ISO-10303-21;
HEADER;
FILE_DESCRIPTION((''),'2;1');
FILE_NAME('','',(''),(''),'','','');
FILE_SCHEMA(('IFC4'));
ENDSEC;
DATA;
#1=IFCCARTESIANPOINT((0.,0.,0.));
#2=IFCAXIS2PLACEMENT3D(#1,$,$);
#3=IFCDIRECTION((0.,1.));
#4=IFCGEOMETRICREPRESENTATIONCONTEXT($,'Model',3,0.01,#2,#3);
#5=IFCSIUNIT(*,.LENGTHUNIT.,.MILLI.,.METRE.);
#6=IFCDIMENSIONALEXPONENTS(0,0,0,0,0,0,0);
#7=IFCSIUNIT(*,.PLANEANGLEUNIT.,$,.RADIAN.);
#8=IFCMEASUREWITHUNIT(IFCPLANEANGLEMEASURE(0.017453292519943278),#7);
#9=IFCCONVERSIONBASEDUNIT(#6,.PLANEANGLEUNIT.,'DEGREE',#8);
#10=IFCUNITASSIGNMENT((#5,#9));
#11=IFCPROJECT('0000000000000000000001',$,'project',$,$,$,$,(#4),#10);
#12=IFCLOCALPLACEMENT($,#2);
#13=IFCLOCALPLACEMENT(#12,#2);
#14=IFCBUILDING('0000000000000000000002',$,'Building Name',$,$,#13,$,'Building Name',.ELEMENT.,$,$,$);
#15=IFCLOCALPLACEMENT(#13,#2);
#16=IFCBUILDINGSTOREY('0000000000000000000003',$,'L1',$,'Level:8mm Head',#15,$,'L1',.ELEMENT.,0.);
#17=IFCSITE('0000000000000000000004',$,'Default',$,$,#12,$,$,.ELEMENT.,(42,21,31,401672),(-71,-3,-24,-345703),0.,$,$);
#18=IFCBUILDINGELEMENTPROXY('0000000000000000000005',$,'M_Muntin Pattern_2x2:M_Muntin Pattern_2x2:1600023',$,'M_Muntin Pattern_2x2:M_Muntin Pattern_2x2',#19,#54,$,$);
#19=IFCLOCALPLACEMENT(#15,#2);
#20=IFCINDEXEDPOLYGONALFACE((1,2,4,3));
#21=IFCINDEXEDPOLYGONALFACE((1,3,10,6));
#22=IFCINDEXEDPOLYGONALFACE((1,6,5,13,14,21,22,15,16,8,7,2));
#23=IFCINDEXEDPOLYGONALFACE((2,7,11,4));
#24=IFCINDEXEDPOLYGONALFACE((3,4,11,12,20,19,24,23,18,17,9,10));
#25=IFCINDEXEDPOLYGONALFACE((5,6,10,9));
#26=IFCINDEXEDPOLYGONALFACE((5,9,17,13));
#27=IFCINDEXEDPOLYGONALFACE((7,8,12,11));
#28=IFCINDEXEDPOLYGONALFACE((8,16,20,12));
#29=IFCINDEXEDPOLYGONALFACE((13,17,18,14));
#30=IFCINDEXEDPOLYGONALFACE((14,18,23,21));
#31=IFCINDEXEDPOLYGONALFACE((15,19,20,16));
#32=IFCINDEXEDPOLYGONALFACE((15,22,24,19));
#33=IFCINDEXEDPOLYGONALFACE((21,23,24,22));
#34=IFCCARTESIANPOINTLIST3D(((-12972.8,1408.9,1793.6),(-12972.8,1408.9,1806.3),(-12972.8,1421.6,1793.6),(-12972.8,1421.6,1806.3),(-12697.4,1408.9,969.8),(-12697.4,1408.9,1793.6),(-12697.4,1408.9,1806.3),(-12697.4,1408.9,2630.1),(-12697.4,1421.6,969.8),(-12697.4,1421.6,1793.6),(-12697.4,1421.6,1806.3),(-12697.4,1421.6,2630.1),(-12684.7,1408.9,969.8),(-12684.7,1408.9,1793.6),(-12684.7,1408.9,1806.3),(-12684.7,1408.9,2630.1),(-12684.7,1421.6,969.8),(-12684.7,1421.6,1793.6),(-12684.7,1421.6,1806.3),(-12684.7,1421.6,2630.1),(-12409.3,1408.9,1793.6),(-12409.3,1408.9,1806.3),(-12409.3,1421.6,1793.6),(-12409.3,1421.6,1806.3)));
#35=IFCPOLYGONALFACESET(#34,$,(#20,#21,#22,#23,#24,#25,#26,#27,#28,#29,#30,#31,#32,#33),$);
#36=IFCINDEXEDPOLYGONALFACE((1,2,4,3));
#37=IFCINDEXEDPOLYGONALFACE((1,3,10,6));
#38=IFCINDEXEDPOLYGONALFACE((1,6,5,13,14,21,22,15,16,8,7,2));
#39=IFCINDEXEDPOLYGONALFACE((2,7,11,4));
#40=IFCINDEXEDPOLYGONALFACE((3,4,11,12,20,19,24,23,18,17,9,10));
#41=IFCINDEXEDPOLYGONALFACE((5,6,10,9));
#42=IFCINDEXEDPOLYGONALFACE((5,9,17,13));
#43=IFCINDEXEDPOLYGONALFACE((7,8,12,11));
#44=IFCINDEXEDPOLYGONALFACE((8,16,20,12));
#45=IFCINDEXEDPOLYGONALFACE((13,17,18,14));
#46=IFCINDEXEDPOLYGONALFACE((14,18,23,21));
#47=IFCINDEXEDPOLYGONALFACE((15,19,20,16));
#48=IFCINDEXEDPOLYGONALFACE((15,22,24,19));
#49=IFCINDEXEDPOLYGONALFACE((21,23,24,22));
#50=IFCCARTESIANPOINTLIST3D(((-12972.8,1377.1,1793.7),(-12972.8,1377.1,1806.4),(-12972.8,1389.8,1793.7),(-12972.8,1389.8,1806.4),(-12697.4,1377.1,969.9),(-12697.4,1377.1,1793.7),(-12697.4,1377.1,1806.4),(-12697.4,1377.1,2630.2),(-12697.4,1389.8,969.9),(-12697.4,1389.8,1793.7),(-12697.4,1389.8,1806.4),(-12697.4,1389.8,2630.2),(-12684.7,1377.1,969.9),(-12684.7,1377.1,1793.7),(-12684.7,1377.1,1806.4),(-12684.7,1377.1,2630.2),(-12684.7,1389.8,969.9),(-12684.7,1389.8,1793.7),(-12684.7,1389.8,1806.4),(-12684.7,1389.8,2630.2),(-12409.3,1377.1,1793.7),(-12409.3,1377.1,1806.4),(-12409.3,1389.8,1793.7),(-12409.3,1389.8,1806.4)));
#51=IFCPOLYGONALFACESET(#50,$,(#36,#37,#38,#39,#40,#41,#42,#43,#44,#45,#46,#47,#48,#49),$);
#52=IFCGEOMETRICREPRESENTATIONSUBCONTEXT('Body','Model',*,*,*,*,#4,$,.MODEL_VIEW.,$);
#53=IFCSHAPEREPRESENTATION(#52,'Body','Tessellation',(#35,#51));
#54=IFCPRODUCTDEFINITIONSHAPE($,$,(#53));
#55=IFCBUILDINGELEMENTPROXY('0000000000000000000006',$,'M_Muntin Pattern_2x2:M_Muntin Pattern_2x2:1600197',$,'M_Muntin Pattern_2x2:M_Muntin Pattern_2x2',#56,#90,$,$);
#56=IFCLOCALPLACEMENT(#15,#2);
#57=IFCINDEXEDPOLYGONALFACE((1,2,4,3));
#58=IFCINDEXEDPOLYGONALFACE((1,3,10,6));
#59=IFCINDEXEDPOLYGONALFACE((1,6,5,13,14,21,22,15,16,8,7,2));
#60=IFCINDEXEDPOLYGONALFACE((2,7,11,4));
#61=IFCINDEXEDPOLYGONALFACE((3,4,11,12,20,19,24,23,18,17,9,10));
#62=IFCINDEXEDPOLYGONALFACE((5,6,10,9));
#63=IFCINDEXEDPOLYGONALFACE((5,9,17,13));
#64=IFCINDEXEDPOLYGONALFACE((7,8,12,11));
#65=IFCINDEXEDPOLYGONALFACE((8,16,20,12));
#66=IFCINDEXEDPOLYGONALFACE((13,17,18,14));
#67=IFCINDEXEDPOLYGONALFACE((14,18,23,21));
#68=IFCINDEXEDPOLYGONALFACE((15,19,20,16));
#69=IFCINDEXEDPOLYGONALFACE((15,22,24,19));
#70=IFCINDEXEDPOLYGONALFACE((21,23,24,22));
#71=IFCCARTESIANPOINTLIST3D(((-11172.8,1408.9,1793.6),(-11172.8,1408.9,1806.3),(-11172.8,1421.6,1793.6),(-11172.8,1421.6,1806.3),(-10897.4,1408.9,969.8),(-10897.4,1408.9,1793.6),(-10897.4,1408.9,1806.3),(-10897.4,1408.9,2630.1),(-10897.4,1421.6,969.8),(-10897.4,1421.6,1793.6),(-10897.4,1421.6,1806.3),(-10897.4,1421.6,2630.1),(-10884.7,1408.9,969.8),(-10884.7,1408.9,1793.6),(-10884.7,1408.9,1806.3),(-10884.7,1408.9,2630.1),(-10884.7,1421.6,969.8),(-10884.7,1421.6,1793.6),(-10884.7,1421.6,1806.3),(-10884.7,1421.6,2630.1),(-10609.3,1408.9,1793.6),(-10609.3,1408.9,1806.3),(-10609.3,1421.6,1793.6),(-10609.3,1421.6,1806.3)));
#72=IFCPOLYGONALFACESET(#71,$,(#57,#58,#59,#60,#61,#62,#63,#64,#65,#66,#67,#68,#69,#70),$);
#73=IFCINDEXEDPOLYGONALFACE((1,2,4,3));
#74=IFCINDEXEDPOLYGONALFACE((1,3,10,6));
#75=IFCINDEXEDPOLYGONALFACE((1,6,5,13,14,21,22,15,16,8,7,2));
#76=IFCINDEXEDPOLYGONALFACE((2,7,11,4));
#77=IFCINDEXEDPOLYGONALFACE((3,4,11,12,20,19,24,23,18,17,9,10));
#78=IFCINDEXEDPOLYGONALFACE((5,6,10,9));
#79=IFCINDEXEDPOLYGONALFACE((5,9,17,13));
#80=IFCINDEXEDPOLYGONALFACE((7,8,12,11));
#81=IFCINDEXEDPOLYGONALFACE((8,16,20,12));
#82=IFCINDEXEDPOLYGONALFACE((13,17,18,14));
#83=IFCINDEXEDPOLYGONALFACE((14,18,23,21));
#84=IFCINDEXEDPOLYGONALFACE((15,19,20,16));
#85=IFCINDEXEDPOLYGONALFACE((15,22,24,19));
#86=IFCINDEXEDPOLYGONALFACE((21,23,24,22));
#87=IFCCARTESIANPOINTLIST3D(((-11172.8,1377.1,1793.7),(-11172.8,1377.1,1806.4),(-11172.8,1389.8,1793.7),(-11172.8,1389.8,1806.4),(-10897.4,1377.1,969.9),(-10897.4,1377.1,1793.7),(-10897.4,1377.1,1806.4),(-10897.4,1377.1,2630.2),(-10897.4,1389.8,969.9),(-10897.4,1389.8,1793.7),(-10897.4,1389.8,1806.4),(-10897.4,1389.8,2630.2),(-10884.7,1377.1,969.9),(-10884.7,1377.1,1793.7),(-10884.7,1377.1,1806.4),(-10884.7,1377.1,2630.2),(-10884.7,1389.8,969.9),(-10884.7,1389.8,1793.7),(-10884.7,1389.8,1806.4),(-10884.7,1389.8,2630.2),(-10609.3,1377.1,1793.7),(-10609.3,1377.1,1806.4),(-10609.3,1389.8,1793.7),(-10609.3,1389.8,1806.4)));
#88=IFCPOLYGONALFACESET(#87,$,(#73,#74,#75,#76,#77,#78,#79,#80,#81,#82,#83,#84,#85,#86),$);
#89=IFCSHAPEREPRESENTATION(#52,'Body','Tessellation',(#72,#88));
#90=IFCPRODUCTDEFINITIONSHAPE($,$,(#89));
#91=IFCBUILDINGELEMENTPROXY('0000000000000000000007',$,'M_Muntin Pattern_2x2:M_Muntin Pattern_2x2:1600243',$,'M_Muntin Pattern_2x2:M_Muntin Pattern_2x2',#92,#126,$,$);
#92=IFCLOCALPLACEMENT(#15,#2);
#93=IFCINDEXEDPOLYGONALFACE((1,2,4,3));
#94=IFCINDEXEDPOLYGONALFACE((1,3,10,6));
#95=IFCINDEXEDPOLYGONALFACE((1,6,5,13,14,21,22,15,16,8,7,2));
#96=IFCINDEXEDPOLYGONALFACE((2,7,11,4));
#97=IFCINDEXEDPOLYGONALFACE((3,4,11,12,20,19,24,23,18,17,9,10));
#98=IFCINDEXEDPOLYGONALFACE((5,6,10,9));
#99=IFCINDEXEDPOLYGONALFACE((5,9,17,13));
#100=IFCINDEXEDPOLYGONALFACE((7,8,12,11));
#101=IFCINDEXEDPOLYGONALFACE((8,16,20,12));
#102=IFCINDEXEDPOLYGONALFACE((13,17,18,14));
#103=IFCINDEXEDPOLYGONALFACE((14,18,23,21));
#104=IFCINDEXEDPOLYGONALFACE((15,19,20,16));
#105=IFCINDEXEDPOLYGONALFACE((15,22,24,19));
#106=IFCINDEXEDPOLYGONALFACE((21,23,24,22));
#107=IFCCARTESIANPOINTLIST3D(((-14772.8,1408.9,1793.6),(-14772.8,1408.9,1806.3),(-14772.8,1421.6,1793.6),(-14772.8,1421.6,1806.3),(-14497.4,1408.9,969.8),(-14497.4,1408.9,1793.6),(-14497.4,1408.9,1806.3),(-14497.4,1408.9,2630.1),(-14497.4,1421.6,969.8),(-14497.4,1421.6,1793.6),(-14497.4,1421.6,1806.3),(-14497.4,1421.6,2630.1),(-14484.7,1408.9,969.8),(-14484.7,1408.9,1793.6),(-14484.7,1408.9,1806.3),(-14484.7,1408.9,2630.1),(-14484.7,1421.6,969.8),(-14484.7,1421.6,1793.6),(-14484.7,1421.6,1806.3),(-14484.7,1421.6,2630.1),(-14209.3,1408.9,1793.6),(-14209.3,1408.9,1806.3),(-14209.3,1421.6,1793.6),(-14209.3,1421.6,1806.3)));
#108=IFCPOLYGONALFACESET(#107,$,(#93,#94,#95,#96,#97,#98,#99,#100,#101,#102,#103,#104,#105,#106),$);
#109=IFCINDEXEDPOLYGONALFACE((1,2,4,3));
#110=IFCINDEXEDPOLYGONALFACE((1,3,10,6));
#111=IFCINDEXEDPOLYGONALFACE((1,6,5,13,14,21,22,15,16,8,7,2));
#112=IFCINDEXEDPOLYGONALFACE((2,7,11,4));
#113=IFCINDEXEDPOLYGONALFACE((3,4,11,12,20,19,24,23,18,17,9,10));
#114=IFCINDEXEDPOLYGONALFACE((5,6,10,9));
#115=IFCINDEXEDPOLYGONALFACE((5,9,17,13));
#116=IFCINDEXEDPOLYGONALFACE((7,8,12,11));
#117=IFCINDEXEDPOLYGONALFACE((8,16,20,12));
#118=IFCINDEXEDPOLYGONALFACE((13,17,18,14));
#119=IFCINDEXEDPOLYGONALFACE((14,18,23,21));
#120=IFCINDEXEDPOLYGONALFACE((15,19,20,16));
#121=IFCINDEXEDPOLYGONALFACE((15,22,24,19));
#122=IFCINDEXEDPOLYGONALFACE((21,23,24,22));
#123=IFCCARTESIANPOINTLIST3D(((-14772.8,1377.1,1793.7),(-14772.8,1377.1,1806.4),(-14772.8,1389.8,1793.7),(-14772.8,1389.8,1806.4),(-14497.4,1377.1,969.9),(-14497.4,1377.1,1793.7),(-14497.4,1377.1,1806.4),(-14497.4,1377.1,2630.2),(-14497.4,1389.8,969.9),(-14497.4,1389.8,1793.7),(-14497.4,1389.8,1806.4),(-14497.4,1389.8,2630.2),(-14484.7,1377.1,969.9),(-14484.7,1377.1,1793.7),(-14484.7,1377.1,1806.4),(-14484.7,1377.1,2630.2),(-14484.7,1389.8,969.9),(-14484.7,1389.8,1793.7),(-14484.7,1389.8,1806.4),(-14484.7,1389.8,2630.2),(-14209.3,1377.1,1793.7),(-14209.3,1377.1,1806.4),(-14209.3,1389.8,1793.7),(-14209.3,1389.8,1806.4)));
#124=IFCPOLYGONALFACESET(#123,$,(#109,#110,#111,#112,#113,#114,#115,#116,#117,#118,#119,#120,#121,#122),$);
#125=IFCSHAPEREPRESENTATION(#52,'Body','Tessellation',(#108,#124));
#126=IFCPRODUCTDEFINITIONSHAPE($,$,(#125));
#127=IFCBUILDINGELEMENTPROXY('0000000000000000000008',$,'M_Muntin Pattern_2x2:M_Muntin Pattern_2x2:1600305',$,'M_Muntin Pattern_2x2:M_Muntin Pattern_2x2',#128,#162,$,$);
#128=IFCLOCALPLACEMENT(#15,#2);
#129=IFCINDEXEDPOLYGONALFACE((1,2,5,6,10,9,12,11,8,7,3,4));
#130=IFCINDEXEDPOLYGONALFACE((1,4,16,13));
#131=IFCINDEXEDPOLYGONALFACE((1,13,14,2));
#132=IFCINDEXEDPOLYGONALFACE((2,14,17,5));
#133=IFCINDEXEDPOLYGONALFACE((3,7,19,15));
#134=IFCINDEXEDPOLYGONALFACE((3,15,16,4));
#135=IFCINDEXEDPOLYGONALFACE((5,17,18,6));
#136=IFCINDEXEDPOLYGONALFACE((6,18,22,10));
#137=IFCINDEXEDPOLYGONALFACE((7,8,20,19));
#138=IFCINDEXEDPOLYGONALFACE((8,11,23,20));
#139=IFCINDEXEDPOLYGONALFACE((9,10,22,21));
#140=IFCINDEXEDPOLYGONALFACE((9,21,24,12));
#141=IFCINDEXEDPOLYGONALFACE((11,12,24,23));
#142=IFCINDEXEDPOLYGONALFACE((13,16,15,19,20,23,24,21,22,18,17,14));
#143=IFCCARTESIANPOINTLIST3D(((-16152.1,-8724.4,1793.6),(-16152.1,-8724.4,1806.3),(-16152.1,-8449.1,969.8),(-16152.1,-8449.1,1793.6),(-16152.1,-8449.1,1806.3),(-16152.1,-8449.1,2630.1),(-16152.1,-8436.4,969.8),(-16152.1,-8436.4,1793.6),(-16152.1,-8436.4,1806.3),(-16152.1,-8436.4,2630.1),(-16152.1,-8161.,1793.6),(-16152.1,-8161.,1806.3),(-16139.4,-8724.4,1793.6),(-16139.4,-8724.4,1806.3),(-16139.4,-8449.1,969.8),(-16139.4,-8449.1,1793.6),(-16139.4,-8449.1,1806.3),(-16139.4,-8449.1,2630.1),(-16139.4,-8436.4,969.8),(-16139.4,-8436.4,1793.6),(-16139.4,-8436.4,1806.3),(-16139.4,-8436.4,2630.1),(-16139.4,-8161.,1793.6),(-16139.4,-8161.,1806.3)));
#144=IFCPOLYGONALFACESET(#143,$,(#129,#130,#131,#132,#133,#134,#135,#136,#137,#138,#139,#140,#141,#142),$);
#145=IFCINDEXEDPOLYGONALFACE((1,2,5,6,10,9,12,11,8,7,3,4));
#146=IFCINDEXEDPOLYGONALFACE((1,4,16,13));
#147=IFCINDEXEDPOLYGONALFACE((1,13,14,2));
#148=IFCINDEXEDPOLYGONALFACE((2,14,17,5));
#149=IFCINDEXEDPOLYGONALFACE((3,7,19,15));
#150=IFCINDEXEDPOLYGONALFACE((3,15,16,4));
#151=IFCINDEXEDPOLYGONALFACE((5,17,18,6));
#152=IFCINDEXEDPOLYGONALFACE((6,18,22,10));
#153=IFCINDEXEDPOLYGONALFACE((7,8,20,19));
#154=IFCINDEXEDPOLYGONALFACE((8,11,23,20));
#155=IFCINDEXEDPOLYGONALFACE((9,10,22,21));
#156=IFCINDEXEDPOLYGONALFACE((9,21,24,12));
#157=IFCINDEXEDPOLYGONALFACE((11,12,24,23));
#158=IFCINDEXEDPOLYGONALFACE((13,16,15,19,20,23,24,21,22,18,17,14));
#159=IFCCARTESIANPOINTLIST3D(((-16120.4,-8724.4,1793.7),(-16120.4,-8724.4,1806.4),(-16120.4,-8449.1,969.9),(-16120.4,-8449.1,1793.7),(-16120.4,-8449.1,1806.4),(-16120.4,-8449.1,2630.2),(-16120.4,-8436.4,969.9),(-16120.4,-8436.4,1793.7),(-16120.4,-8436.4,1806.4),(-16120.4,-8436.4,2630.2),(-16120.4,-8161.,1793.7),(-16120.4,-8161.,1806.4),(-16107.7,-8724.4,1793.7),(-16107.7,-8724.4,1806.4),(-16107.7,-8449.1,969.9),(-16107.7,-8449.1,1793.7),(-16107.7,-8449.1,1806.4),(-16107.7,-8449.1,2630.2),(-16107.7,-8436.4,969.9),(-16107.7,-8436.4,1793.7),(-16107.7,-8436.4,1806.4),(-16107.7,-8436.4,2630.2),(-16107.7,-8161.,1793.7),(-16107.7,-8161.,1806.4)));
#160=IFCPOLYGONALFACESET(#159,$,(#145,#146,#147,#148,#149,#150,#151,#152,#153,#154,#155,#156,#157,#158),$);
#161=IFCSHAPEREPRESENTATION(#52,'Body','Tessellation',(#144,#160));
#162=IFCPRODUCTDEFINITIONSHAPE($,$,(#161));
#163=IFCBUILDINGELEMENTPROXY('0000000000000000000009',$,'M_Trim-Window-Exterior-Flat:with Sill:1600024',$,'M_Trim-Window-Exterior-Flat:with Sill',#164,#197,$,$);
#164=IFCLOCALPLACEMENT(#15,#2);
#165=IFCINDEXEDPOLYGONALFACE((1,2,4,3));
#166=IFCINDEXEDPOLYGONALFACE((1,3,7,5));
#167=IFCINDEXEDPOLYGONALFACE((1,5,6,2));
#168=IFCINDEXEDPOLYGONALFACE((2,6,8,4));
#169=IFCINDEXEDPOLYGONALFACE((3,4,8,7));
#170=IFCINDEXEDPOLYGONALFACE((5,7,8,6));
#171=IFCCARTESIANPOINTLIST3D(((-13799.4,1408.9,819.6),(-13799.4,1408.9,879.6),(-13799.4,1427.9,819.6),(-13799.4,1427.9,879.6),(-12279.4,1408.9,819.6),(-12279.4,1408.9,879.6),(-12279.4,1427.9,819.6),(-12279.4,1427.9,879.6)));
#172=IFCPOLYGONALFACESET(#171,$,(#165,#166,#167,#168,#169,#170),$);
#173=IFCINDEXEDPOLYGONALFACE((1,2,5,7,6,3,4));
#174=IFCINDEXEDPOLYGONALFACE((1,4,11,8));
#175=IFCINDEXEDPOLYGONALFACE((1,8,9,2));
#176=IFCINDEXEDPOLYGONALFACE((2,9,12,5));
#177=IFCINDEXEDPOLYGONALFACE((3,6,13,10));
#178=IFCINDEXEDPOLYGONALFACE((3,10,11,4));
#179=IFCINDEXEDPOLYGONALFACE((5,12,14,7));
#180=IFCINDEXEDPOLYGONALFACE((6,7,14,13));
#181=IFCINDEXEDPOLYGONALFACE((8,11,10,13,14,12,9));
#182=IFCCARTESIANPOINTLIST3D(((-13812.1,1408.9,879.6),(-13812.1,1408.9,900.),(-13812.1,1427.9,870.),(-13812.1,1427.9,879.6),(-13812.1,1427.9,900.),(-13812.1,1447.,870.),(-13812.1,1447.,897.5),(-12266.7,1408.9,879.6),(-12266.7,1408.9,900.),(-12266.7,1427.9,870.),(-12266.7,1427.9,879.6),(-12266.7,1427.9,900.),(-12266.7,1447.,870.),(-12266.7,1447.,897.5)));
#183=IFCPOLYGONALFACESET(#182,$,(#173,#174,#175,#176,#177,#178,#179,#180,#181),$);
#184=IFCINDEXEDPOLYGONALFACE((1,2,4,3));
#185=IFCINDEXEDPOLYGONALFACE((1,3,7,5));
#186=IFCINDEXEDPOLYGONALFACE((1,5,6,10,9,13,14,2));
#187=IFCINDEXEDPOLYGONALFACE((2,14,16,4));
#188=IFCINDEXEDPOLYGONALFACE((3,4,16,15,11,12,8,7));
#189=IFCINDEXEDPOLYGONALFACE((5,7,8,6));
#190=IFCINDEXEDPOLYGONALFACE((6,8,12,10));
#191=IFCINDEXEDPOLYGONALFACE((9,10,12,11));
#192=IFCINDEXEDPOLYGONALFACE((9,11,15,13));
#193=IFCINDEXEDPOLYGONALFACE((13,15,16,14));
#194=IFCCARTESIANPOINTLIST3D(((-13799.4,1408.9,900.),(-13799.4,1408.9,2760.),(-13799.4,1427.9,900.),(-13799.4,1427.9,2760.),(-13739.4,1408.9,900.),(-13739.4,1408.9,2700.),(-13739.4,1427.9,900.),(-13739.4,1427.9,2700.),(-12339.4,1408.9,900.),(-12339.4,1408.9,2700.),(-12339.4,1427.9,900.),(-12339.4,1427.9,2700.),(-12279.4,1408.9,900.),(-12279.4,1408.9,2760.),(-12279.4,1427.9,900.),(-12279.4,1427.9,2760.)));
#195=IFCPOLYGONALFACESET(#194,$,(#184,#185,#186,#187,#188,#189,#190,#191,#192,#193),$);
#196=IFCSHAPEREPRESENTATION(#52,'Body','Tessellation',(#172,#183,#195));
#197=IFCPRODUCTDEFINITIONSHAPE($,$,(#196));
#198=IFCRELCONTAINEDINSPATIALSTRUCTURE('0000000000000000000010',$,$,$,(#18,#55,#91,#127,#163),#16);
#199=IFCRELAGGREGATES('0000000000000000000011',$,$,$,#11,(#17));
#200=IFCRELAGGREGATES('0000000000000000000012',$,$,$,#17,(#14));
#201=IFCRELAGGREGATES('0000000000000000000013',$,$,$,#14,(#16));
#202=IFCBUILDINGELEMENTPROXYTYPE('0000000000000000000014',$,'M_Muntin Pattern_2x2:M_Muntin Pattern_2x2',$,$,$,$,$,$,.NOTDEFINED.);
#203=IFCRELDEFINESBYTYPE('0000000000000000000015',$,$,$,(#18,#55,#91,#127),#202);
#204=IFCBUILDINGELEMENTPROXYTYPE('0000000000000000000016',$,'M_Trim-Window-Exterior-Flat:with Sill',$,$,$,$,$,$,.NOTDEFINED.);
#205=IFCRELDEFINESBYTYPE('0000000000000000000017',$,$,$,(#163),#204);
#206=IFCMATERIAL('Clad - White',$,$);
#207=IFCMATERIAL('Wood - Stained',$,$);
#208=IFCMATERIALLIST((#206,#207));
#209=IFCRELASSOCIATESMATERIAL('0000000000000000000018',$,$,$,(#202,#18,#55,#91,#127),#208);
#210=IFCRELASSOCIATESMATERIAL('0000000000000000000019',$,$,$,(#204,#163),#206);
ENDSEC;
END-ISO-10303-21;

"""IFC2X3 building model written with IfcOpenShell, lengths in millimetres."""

from ifc_helpers import new_model, entity, si_unit, converted_unit, direction, frame, frame_2d, origin, place, context, subcontext, project, spatial, polyline, rectangle, outline, extrude, source, transform, mapped, material, material_list, type_object, type_shapes, element, save


model = new_model("IFC2X3")

# Units and contexts
model_context = context("Model", 3, precision=0.01, world=origin(), true_north=direction((0.0, 1.0)))
body_context = subcontext(model_context, "Body", "Model", "MODEL_VIEW")
ifc_project = project(units=[si_unit("LENGTHUNIT", "METRE", prefix="MILLI"), converted_unit("PLANEANGLEUNIT", "DEGREE", entity("IfcPlaneAngleMeasure", 0.017453292519943278), si_unit("PLANEANGLEUNIT", "RADIAN"), dimensions=[0, 0, 0, 0, 0, 0, 0])], contexts=[model_context])

# Site, building, storey
site_placement = place(None, origin())
site = spatial("IfcSite", under=ifc_project, at=site_placement, Name="Default", CompositionType="ELEMENT", RefLatitude=(42, 21, 31, 401672), RefLongitude=(-71, -3, -24, -345703), RefElevation=0.0)
building_placement = place(site_placement, origin())
building = spatial("IfcBuilding", under=site, at=building_placement, Name="Building Name", LongName="Building Name", CompositionType="ELEMENT")
storey_placement = place(building_placement, origin())
storey = spatial("IfcBuildingStorey", under=building, at=storey_placement, Name="L1", ObjectType="Level:8mm Head", LongName="L1", CompositionType="ELEMENT", Elevation=0.0)

# Building element proxies
ifc_material_1 = material(Name="Clad - White")
ifc_material_2 = material(Name="Wood - Stained")
ifc_material_list = material_list([ifc_material_1, ifc_material_2])
building_element_proxy_type_1 = type_object("IfcBuildingElementProxyType", Name="M_Muntin Pattern_2x2:M_Muntin Pattern_2x2", PredefinedType="NOTDEFINED", material=ifc_material_list)
shared_shape_1 = source(origin(), body_context, "Body", "SweptSolid", [
    extrude(outline(polyline([(6.4, -6.4), (830.1, -6.4), (830.1, 6.3), (6.4, 6.3), (6.4, 281.7), (-6.3, 281.7), (-6.3, 6.3), (-830.2, 6.3), (-830.2, -6.4), (-6.3, -6.4), (-6.3, -281.7), (6.4, -281.7), (6.4, -6.4)])), frame((0.0, -22.2, 830.1), z_axis=(0.0, 1.0, 0.0), x_axis=(0.0, 0.0, 1.0)), (0.0, 0.0, 1.0), 12.7),
    extrude(outline(polyline([(6.4, -6.4), (830.2, -6.4), (830.2, 6.3), (6.4, 6.3), (6.4, 281.7), (-6.3, 281.7), (-6.3, 6.3), (-830.2, 6.3), (-830.2, -6.4), (-6.3, -6.4), (-6.3, -281.7), (6.4, -281.7), (6.4, -6.4)])), frame((0.0, 9.5, 830.2), z_axis=(0.0, 1.0, 0.0), x_axis=(0.0, 0.0, 1.0)), (0.0, 0.0, 1.0), 12.7),
])
type_shapes(building_element_proxy_type_1, [shared_shape_1])
for number, where, z_axis, x_axis, name in (
    (1, (-12691.0, 1399.4, 969.9), (0.0, 0.0, 1.0), (-1.0, 0.0, 0.0), "M_Muntin Pattern_2x2:M_Muntin Pattern_2x2:1600023"),
    (2, (-10891.0, 1399.4, 969.9), (0.0, 0.0, 1.0), (-1.0, 0.0, 0.0), "M_Muntin Pattern_2x2:M_Muntin Pattern_2x2:1600197"),
    (3, (-14491.0, 1399.4, 969.9), (0.0, 0.0, 1.0), (-1.0, 0.0, 0.0), "M_Muntin Pattern_2x2:M_Muntin Pattern_2x2:1600243"),
    (4, (-16129.9, -8442.7, 969.9), (0.0, 0.0, 1.0), (0.0, -1.0, 0.0), "M_Muntin Pattern_2x2:M_Muntin Pattern_2x2:1600305"),
):
    element("IfcBuildingElementProxy", number, at=place(storey_placement, frame(where, z_axis=z_axis, x_axis=x_axis)), inside=storey, type_object=building_element_proxy_type_1, material=ifc_material_list, Name=name, ObjectType="M_Muntin Pattern_2x2:M_Muntin Pattern_2x2", context=body_context, shape_type="MappedRepresentation", body=[
        mapped(shared_shape_1, transform((0.0, 0.0, 0.0), scale=1.0)),
    ])
building_element_proxy_type_2 = type_object("IfcBuildingElementProxyType", Name="M_Trim-Window-Exterior-Flat:with Sill", PredefinedType="NOTDEFINED", material=ifc_material_1)
shared_shape_2 = source(origin(), body_context, "Body", "SweptSolid", [
    extrude(rectangle(XDim=1520.0, YDim=60.0, at=frame_2d((0.0, 0.0), x_axis=(1.0, 0.0))), frame((0.0, -1850.4, 0.0), z_axis=(0.0, 0.0, 1.0), x_axis=(-1.0, 0.0, 0.0)), (0.0, 0.0, 1.0), 19.0),
    extrude(outline(polyline([(-19.0, -15.2), (0.0, -15.2), (0.0, -5.7), (19.0, -5.7), (19.0, 14.8), (0.0, 14.8), (-19.0, 12.3), (-19.0, -15.2)])), frame((-772.7, -1814.8, 19.0), z_axis=(1.0, 0.0, 0.0), x_axis=(0.0, 0.0, -1.0)), (0.0, 0.0, 1.0), 1545.4),
    extrude(outline(polyline([(-945.0, -760.0), (915.0, -760.0), (915.0, -700.0), (-885.0, -700.0), (-885.0, 700.0), (915.0, 700.0), (915.0, 760.0), (-945.0, 760.0), (-945.0, -760.0)])), frame((0.0, -885.0, 0.0), z_axis=(0.0, 0.0, 1.0), x_axis=(0.0, -1.0, 0.0)), (0.0, 0.0, 1.0), 19.0),
])
type_shapes(building_element_proxy_type_2, [shared_shape_2])
for number, where, z_axis, x_axis, name in (
    (5, (-13039.4, 1408.9, 2700.0), (0.0, 1.0, 0.0), (-1.0, 0.0, 0.0), "M_Trim-Window-Exterior-Flat:with Sill:1600024"),
):
    element("IfcBuildingElementProxy", number, at=place(storey_placement, frame(where, z_axis=z_axis, x_axis=x_axis)), inside=storey, type_object=building_element_proxy_type_2, material=ifc_material_1, Name=name, ObjectType="M_Trim-Window-Exterior-Flat:with Sill", context=body_context, shape_type="MappedRepresentation", body=[
        mapped(shared_shape_2, transform((0.0, 0.0, 0.0), scale=1.0)),
    ])

save(model, "model.ifc")
